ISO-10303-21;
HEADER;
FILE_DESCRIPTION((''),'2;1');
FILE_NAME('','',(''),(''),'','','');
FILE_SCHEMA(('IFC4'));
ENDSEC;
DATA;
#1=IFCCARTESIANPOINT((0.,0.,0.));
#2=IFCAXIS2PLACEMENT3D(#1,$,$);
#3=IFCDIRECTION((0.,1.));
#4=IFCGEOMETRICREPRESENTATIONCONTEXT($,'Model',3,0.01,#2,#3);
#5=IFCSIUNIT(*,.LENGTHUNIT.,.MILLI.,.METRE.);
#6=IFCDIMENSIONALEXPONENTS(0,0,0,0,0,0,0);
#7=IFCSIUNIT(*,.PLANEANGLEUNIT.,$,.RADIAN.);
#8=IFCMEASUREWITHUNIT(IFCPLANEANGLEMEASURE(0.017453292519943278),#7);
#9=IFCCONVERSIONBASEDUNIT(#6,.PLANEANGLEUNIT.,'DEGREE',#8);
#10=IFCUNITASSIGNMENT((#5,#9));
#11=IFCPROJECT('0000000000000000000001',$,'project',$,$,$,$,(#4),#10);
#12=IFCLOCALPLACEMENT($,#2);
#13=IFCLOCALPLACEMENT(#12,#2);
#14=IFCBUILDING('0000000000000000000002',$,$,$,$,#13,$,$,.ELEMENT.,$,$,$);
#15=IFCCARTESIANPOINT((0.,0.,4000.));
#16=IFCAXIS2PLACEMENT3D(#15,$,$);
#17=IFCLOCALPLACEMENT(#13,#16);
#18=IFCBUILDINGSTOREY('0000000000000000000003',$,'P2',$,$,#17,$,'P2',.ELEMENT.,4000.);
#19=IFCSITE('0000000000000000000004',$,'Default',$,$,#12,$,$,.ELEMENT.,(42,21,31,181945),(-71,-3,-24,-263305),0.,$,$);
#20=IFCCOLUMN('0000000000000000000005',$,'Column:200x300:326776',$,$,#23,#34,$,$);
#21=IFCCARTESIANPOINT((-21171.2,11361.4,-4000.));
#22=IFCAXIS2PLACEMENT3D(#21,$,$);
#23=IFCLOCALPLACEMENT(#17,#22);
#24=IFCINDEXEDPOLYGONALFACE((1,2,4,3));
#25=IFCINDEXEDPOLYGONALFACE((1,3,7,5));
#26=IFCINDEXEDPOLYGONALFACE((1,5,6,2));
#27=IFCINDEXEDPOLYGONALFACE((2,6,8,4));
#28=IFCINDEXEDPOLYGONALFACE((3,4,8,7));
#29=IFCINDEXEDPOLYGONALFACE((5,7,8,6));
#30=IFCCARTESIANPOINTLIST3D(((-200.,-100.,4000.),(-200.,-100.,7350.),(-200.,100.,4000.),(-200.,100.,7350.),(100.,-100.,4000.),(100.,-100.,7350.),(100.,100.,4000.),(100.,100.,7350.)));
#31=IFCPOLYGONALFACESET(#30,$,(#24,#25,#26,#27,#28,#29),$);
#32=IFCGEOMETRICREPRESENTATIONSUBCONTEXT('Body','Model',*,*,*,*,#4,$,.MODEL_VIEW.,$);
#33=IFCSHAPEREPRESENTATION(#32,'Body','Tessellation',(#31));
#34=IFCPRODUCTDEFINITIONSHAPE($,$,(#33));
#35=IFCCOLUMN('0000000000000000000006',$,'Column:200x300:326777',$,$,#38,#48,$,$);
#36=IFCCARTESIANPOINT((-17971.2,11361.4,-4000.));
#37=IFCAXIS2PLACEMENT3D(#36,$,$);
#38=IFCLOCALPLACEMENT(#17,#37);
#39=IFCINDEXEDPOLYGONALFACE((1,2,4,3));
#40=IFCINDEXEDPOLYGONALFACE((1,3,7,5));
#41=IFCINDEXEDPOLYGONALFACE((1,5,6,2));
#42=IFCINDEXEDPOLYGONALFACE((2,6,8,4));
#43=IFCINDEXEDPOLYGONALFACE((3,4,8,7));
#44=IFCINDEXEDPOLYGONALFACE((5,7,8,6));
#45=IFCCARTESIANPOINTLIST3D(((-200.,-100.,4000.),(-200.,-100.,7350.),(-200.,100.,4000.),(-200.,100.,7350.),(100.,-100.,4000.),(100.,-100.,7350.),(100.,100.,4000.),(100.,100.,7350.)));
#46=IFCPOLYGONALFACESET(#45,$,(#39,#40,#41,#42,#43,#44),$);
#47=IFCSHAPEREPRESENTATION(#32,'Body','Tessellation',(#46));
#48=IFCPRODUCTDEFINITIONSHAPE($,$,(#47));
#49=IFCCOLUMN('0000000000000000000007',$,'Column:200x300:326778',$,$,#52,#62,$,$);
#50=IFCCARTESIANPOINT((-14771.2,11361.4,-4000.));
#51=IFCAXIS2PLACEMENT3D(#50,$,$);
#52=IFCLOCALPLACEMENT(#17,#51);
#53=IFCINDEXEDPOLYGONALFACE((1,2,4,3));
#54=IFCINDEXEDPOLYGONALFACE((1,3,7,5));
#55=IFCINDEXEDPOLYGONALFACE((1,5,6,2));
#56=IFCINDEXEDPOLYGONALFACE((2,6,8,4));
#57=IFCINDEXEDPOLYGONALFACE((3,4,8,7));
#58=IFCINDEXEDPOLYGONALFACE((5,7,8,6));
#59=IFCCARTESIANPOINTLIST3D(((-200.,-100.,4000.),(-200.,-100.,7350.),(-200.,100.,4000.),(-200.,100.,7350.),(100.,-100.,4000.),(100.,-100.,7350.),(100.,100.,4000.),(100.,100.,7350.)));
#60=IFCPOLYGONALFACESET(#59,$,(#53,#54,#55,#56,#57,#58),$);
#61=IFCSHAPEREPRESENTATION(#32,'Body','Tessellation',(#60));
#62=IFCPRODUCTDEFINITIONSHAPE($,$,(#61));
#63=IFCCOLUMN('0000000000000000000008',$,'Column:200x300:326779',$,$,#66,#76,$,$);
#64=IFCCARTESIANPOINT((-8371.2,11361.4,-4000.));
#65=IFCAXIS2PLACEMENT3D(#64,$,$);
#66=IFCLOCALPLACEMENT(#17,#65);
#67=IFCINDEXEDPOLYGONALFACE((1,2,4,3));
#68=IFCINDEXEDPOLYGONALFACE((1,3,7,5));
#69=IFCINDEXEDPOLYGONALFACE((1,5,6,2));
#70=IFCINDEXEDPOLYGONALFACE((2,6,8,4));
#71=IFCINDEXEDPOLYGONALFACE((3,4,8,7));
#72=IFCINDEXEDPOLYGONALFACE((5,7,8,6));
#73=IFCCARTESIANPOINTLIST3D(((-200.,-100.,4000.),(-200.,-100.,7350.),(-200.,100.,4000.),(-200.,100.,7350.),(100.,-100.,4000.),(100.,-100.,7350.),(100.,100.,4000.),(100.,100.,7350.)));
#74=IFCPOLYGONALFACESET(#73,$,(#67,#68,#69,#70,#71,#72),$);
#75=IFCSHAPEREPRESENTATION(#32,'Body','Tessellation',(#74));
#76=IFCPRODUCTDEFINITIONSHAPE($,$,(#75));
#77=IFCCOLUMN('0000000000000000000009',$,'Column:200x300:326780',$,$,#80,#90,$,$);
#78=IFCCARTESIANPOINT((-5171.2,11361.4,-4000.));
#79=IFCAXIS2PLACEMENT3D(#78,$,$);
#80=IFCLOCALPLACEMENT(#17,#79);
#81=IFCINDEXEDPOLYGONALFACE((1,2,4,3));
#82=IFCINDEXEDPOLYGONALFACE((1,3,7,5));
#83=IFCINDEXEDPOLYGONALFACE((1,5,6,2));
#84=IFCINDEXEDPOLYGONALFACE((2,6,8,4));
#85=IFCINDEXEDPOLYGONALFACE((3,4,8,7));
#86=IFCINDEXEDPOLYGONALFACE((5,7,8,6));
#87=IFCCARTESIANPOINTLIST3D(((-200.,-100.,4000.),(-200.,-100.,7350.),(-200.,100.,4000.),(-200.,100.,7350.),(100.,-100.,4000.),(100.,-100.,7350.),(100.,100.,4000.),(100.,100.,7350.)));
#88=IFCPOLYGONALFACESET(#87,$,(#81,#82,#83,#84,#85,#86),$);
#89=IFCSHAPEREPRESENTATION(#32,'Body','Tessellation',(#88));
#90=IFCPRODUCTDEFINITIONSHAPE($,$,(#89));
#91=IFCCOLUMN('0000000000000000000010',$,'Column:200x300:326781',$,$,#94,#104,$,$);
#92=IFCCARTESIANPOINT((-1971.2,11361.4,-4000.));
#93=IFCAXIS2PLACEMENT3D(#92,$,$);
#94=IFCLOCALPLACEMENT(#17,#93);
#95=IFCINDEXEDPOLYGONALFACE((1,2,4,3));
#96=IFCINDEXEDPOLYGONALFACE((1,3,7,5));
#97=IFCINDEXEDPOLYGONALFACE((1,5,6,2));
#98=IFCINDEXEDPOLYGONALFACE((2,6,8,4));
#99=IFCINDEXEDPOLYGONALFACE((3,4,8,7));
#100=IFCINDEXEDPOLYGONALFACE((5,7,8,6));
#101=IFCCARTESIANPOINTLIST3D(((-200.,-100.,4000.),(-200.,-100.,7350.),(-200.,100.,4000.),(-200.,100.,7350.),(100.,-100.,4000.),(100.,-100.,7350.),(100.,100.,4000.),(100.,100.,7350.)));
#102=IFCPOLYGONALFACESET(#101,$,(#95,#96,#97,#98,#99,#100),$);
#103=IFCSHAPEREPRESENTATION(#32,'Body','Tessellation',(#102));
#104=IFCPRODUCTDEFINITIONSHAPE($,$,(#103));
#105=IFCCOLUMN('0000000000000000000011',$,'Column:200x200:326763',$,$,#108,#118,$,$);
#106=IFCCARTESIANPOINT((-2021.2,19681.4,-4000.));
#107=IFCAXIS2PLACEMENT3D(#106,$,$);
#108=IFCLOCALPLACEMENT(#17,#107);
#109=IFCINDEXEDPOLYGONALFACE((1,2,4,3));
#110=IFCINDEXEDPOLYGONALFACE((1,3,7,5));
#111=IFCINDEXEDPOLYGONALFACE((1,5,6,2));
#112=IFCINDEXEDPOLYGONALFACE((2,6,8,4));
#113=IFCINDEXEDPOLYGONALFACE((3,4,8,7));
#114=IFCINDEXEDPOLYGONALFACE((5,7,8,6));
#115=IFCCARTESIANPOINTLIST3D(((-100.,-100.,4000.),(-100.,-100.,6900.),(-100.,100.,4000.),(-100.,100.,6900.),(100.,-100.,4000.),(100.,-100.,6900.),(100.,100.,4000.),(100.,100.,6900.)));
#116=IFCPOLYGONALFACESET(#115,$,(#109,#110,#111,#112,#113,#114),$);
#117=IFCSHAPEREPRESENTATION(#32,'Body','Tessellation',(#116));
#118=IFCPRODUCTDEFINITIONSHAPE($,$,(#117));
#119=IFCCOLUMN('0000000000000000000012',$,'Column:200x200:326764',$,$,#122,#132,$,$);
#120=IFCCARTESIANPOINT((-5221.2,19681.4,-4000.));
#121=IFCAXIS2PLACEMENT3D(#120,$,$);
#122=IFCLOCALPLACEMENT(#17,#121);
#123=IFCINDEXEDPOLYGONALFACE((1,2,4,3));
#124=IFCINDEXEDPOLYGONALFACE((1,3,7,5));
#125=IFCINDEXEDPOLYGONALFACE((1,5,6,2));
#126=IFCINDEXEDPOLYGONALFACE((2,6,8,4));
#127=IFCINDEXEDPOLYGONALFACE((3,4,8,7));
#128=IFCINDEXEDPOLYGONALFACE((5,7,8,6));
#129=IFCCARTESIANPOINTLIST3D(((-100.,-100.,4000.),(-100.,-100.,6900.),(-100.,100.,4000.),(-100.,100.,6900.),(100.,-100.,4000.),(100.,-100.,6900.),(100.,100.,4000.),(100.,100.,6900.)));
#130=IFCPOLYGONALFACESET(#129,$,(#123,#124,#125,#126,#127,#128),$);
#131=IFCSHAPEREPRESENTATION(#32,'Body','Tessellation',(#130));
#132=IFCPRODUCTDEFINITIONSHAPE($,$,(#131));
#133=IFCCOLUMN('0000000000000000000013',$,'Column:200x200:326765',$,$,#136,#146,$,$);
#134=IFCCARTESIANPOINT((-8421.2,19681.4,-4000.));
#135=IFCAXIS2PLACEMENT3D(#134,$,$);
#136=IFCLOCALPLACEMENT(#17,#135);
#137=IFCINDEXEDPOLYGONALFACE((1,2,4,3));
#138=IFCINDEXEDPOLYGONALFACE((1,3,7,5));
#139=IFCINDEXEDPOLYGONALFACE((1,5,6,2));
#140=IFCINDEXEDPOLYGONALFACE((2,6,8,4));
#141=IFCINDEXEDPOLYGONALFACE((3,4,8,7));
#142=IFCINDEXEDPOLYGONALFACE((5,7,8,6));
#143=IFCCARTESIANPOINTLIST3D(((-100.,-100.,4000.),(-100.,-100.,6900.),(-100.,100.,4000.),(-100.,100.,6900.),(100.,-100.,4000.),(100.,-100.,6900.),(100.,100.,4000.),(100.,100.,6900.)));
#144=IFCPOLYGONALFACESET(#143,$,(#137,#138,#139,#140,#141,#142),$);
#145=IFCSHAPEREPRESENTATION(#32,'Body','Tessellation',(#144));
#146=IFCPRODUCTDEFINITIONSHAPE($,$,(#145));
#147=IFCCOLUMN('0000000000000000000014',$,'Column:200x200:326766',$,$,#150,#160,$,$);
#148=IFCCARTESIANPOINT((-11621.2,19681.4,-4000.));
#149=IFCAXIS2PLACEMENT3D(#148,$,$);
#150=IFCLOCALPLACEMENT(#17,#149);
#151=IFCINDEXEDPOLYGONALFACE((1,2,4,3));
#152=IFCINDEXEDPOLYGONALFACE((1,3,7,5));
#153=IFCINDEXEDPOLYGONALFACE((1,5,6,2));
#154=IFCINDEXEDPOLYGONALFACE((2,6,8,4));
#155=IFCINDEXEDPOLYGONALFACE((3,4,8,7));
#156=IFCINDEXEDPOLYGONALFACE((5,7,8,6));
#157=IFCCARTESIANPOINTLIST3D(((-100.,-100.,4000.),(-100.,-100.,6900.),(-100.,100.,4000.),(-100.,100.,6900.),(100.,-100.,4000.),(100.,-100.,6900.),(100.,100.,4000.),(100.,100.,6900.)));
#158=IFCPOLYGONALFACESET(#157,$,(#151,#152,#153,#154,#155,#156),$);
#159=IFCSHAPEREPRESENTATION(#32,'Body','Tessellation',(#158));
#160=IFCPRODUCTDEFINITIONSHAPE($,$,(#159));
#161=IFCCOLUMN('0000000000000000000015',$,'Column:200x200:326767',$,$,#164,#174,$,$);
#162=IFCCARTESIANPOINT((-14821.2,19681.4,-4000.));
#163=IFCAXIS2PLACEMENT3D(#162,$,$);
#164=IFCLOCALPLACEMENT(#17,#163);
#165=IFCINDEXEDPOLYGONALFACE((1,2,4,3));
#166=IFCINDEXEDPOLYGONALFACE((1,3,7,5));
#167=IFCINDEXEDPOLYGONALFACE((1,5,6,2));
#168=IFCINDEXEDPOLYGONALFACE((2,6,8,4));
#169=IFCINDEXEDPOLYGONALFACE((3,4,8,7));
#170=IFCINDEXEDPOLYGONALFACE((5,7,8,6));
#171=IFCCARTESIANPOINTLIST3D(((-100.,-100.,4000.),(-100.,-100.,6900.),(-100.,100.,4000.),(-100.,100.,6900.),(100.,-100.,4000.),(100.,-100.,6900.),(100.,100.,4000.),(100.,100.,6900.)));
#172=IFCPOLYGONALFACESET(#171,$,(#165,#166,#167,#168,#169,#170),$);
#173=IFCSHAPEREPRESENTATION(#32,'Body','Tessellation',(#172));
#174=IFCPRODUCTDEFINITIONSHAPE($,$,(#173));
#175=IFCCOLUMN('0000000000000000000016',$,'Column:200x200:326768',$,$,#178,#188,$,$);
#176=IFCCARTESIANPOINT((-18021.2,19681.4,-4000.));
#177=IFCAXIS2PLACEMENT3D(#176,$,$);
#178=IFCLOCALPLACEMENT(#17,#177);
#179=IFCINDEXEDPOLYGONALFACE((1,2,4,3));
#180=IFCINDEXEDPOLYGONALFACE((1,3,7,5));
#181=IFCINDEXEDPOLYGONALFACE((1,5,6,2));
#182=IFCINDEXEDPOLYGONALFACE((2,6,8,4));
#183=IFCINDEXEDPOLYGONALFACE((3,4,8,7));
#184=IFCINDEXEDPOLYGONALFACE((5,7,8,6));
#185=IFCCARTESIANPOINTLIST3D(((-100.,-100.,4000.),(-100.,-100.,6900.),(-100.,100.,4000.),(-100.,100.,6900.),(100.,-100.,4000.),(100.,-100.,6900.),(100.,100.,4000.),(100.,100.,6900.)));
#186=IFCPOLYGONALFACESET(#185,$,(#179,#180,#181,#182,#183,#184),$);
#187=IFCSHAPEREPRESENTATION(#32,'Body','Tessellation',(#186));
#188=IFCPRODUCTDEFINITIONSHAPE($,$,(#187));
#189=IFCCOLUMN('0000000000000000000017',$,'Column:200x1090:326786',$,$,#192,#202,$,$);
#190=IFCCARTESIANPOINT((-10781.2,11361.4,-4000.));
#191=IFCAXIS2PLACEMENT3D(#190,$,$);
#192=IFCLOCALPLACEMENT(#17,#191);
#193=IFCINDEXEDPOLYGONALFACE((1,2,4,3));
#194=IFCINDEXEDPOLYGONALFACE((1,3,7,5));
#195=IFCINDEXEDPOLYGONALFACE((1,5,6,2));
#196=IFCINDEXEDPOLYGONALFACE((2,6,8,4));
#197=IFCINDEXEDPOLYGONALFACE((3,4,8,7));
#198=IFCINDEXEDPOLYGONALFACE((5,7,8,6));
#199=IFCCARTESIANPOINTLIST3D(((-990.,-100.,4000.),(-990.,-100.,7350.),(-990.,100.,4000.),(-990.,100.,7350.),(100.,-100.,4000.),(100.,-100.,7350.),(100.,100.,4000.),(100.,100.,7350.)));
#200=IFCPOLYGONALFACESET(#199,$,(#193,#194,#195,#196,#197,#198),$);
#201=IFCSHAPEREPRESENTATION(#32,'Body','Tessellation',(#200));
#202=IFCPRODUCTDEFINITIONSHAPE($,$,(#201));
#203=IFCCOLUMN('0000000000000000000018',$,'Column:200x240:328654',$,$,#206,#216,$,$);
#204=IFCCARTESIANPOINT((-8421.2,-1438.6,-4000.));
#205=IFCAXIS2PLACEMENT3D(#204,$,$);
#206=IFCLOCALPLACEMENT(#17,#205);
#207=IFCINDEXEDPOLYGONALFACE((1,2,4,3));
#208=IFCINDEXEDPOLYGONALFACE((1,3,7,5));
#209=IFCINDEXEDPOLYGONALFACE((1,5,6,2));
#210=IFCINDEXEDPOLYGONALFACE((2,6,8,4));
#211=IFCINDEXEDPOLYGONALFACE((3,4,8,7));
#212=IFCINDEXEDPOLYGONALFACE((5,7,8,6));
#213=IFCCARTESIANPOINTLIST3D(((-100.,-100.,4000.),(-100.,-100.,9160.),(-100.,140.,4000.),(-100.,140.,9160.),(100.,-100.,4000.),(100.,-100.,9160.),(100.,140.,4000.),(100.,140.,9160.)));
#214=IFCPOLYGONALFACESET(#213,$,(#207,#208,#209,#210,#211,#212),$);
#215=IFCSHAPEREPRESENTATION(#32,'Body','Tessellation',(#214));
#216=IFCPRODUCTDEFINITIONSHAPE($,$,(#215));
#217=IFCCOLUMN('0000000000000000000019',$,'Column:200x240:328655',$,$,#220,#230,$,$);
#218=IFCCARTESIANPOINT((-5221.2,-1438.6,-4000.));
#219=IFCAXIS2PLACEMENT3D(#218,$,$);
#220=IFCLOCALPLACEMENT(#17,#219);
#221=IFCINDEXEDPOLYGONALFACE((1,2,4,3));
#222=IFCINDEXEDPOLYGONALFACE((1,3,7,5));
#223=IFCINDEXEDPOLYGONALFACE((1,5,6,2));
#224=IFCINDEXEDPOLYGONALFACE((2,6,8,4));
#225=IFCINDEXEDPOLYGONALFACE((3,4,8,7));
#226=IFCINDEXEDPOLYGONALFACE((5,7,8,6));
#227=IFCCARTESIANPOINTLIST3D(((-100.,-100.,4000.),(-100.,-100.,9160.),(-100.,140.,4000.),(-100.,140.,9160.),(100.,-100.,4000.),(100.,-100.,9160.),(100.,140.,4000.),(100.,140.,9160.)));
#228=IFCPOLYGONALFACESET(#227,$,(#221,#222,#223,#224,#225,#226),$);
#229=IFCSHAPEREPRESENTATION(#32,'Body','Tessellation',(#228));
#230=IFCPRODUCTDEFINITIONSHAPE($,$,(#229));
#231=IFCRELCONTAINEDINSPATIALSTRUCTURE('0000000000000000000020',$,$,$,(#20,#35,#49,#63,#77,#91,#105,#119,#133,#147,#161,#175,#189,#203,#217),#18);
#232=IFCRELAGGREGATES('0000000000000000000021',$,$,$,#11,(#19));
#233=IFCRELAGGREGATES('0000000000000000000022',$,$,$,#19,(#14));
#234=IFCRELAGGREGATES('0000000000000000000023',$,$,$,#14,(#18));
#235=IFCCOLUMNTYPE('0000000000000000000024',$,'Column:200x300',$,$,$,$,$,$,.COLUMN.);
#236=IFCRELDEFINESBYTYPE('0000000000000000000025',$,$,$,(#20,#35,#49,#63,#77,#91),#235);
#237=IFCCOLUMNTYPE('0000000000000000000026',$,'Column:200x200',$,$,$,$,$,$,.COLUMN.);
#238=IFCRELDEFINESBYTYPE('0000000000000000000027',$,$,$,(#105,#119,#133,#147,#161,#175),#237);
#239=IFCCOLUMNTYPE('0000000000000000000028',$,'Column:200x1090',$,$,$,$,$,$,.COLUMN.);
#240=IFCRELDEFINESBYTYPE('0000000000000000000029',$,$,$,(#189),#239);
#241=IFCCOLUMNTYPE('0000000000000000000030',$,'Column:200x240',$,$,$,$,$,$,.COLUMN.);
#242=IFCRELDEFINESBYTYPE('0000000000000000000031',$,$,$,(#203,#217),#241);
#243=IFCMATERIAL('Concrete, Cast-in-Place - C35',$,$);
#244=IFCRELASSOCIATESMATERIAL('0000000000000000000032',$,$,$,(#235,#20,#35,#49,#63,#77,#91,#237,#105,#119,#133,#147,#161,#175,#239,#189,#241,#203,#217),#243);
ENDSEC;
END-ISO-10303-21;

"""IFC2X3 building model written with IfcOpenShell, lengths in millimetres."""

from ifc_helpers import new_model, entity, si_unit, converted_unit, direction, frame, frame_2d, origin, origin_2d_with_axis, place, context, subcontext, project, spatial, rectangle, extrude, source, transform, mapped, material, type_object, type_shapes, element, save


model = new_model("IFC2X3")

# Units and contexts
model_context = context("Model", 3, precision=0.01, world=origin(), true_north=direction((0.0, 1.0)))
body_context = subcontext(model_context, "Body", "Model", "MODEL_VIEW")
ifc_project = project(units=[si_unit("LENGTHUNIT", "METRE", prefix="MILLI"), converted_unit("PLANEANGLEUNIT", "DEGREE", entity("IfcPlaneAngleMeasure", 0.017453292519943278), si_unit("PLANEANGLEUNIT", "RADIAN"), dimensions=[0, 0, 0, 0, 0, 0, 0])], contexts=[model_context])

# Site, building, storey
site_placement = place(None, origin())
site = spatial("IfcSite", under=ifc_project, at=site_placement, Name="Default", CompositionType="ELEMENT", RefLatitude=(42, 21, 31, 181945), RefLongitude=(-71, -3, -24, -263305), RefElevation=0.0)
building_placement = place(site_placement, origin())
building = spatial("IfcBuilding", under=site, at=building_placement, CompositionType="ELEMENT")
storey_placement = place(building_placement, frame((0.0, 0.0, 4000.0)))
storey = spatial("IfcBuildingStorey", under=building, at=storey_placement, Name="P2", LongName="P2", CompositionType="ELEMENT", Elevation=4000.0)

# Columns
ifc_material = material(Name="Concrete, Cast-in-Place - C35")
column_type_1 = type_object("IfcColumnType", Name="Column:200x300", PredefinedType="COLUMN", material=ifc_material)
shared_shape_1 = source(origin(), body_context, "Body", "SweptSolid", [
    extrude(rectangle(XDim=300.0, YDim=200.0, at=origin_2d_with_axis()), frame((-50.0, 0.0, 4000.0), z_axis=(0.0, 0.0, 1.0), x_axis=(-1.0, 0.0, 0.0)), (0.0, 0.0, 1.0), 3350.0),
])
type_shapes(column_type_1, [shared_shape_1])
for number, where, name in (
    (1, (-21171.2, 11361.4, -4000.0), "Column:200x300:326776"),
    (2, (-17971.2, 11361.4, -4000.0), "Column:200x300:326777"),
    (3, (-14771.2, 11361.4, -4000.0), "Column:200x300:326778"),
    (4, (-8371.2, 11361.4, -4000.0), "Column:200x300:326779"),
    (5, (-5171.2, 11361.4, -4000.0), "Column:200x300:326780"),
    (6, (-1971.2, 11361.4, -4000.0), "Column:200x300:326781"),
):
    element("IfcColumn", number, at=place(storey_placement, frame(where)), inside=storey, type_object=column_type_1, material=ifc_material, Name=name, context=body_context, shape_type="MappedRepresentation", body=[
        mapped(shared_shape_1, transform((0.0, 0.0, 0.0), scale=1.0)),
    ])
column_type_2 = type_object("IfcColumnType", Name="Column:200x200", PredefinedType="COLUMN", material=ifc_material)
shared_shape_2 = source(origin(), body_context, "Body", "SweptSolid", [
    extrude(rectangle(XDim=200.0, YDim=200.0, at=frame_2d((0.0, 0.0), x_axis=(1.0, 0.0))), frame((0.0, 0.0, 4000.0), z_axis=(0.0, 0.0, 1.0), x_axis=(-1.0, 0.0, 0.0)), (0.0, 0.0, 1.0), 2900.0),
])
type_shapes(column_type_2, [shared_shape_2])
for number, where, name in (
    (7, (-2021.2, 19681.4, -4000.0), "Column:200x200:326763"),
    (8, (-5221.2, 19681.4, -4000.0), "Column:200x200:326764"),
    (9, (-8421.2, 19681.4, -4000.0), "Column:200x200:326765"),
    (10, (-11621.2, 19681.4, -4000.0), "Column:200x200:326766"),
    (11, (-14821.2, 19681.4, -4000.0), "Column:200x200:326767"),
    (12, (-18021.2, 19681.4, -4000.0), "Column:200x200:326768"),
):
    element("IfcColumn", number, at=place(storey_placement, frame(where)), inside=storey, type_object=column_type_2, material=ifc_material, Name=name, context=body_context, shape_type="MappedRepresentation", body=[
        mapped(shared_shape_2, transform((0.0, 0.0, 0.0), scale=1.0)),
    ])
column_type_3 = type_object("IfcColumnType", Name="Column:200x1090", PredefinedType="COLUMN", material=ifc_material)
shared_shape_3 = source(origin(), body_context, "Body", "SweptSolid", [
    extrude(rectangle(XDim=1090.0, YDim=200.0, at=origin_2d_with_axis()), frame((-445.0, 0.0, 4000.0), z_axis=(0.0, 0.0, 1.0), x_axis=(-1.0, 0.0, 0.0)), (0.0, 0.0, 1.0), 3350.0),
])
type_shapes(column_type_3, [shared_shape_3])
column_1_placement = place(storey_placement, frame((-10781.2, 11361.4, -4000.0)))
element("IfcColumn", 13, at=column_1_placement, inside=storey, type_object=column_type_3, material=ifc_material, Name="Column:200x1090:326786", context=body_context, shape_type="MappedRepresentation", body=[
    mapped(shared_shape_3, transform((0.0, 0.0, 0.0), scale=1.0)),
])
column_type_4 = type_object("IfcColumnType", Name="Column:200x240", PredefinedType="COLUMN", material=ifc_material)
shared_shape_4 = source(origin(), body_context, "Body", "SweptSolid", [
    extrude(rectangle(XDim=200.0, YDim=240.0, at=origin_2d_with_axis()), frame((0.0, 20.0, 4000.0), z_axis=(0.0, 0.0, 1.0), x_axis=(-1.0, 0.0, 0.0)), (0.0, 0.0, 1.0), 5160.0),
])
type_shapes(column_type_4, [shared_shape_4])
for number, where, name in (
    (14, (-8421.2, -1438.6, -4000.0), "Column:200x240:328654"),
    (15, (-5221.2, -1438.6, -4000.0), "Column:200x240:328655"),
):
    element("IfcColumn", number, at=place(storey_placement, frame(where)), inside=storey, type_object=column_type_4, material=ifc_material, Name=name, context=body_context, shape_type="MappedRepresentation", body=[
        mapped(shared_shape_4, transform((0.0, 0.0, 0.0), scale=1.0)),
    ])

save(model, "model.ifc")
